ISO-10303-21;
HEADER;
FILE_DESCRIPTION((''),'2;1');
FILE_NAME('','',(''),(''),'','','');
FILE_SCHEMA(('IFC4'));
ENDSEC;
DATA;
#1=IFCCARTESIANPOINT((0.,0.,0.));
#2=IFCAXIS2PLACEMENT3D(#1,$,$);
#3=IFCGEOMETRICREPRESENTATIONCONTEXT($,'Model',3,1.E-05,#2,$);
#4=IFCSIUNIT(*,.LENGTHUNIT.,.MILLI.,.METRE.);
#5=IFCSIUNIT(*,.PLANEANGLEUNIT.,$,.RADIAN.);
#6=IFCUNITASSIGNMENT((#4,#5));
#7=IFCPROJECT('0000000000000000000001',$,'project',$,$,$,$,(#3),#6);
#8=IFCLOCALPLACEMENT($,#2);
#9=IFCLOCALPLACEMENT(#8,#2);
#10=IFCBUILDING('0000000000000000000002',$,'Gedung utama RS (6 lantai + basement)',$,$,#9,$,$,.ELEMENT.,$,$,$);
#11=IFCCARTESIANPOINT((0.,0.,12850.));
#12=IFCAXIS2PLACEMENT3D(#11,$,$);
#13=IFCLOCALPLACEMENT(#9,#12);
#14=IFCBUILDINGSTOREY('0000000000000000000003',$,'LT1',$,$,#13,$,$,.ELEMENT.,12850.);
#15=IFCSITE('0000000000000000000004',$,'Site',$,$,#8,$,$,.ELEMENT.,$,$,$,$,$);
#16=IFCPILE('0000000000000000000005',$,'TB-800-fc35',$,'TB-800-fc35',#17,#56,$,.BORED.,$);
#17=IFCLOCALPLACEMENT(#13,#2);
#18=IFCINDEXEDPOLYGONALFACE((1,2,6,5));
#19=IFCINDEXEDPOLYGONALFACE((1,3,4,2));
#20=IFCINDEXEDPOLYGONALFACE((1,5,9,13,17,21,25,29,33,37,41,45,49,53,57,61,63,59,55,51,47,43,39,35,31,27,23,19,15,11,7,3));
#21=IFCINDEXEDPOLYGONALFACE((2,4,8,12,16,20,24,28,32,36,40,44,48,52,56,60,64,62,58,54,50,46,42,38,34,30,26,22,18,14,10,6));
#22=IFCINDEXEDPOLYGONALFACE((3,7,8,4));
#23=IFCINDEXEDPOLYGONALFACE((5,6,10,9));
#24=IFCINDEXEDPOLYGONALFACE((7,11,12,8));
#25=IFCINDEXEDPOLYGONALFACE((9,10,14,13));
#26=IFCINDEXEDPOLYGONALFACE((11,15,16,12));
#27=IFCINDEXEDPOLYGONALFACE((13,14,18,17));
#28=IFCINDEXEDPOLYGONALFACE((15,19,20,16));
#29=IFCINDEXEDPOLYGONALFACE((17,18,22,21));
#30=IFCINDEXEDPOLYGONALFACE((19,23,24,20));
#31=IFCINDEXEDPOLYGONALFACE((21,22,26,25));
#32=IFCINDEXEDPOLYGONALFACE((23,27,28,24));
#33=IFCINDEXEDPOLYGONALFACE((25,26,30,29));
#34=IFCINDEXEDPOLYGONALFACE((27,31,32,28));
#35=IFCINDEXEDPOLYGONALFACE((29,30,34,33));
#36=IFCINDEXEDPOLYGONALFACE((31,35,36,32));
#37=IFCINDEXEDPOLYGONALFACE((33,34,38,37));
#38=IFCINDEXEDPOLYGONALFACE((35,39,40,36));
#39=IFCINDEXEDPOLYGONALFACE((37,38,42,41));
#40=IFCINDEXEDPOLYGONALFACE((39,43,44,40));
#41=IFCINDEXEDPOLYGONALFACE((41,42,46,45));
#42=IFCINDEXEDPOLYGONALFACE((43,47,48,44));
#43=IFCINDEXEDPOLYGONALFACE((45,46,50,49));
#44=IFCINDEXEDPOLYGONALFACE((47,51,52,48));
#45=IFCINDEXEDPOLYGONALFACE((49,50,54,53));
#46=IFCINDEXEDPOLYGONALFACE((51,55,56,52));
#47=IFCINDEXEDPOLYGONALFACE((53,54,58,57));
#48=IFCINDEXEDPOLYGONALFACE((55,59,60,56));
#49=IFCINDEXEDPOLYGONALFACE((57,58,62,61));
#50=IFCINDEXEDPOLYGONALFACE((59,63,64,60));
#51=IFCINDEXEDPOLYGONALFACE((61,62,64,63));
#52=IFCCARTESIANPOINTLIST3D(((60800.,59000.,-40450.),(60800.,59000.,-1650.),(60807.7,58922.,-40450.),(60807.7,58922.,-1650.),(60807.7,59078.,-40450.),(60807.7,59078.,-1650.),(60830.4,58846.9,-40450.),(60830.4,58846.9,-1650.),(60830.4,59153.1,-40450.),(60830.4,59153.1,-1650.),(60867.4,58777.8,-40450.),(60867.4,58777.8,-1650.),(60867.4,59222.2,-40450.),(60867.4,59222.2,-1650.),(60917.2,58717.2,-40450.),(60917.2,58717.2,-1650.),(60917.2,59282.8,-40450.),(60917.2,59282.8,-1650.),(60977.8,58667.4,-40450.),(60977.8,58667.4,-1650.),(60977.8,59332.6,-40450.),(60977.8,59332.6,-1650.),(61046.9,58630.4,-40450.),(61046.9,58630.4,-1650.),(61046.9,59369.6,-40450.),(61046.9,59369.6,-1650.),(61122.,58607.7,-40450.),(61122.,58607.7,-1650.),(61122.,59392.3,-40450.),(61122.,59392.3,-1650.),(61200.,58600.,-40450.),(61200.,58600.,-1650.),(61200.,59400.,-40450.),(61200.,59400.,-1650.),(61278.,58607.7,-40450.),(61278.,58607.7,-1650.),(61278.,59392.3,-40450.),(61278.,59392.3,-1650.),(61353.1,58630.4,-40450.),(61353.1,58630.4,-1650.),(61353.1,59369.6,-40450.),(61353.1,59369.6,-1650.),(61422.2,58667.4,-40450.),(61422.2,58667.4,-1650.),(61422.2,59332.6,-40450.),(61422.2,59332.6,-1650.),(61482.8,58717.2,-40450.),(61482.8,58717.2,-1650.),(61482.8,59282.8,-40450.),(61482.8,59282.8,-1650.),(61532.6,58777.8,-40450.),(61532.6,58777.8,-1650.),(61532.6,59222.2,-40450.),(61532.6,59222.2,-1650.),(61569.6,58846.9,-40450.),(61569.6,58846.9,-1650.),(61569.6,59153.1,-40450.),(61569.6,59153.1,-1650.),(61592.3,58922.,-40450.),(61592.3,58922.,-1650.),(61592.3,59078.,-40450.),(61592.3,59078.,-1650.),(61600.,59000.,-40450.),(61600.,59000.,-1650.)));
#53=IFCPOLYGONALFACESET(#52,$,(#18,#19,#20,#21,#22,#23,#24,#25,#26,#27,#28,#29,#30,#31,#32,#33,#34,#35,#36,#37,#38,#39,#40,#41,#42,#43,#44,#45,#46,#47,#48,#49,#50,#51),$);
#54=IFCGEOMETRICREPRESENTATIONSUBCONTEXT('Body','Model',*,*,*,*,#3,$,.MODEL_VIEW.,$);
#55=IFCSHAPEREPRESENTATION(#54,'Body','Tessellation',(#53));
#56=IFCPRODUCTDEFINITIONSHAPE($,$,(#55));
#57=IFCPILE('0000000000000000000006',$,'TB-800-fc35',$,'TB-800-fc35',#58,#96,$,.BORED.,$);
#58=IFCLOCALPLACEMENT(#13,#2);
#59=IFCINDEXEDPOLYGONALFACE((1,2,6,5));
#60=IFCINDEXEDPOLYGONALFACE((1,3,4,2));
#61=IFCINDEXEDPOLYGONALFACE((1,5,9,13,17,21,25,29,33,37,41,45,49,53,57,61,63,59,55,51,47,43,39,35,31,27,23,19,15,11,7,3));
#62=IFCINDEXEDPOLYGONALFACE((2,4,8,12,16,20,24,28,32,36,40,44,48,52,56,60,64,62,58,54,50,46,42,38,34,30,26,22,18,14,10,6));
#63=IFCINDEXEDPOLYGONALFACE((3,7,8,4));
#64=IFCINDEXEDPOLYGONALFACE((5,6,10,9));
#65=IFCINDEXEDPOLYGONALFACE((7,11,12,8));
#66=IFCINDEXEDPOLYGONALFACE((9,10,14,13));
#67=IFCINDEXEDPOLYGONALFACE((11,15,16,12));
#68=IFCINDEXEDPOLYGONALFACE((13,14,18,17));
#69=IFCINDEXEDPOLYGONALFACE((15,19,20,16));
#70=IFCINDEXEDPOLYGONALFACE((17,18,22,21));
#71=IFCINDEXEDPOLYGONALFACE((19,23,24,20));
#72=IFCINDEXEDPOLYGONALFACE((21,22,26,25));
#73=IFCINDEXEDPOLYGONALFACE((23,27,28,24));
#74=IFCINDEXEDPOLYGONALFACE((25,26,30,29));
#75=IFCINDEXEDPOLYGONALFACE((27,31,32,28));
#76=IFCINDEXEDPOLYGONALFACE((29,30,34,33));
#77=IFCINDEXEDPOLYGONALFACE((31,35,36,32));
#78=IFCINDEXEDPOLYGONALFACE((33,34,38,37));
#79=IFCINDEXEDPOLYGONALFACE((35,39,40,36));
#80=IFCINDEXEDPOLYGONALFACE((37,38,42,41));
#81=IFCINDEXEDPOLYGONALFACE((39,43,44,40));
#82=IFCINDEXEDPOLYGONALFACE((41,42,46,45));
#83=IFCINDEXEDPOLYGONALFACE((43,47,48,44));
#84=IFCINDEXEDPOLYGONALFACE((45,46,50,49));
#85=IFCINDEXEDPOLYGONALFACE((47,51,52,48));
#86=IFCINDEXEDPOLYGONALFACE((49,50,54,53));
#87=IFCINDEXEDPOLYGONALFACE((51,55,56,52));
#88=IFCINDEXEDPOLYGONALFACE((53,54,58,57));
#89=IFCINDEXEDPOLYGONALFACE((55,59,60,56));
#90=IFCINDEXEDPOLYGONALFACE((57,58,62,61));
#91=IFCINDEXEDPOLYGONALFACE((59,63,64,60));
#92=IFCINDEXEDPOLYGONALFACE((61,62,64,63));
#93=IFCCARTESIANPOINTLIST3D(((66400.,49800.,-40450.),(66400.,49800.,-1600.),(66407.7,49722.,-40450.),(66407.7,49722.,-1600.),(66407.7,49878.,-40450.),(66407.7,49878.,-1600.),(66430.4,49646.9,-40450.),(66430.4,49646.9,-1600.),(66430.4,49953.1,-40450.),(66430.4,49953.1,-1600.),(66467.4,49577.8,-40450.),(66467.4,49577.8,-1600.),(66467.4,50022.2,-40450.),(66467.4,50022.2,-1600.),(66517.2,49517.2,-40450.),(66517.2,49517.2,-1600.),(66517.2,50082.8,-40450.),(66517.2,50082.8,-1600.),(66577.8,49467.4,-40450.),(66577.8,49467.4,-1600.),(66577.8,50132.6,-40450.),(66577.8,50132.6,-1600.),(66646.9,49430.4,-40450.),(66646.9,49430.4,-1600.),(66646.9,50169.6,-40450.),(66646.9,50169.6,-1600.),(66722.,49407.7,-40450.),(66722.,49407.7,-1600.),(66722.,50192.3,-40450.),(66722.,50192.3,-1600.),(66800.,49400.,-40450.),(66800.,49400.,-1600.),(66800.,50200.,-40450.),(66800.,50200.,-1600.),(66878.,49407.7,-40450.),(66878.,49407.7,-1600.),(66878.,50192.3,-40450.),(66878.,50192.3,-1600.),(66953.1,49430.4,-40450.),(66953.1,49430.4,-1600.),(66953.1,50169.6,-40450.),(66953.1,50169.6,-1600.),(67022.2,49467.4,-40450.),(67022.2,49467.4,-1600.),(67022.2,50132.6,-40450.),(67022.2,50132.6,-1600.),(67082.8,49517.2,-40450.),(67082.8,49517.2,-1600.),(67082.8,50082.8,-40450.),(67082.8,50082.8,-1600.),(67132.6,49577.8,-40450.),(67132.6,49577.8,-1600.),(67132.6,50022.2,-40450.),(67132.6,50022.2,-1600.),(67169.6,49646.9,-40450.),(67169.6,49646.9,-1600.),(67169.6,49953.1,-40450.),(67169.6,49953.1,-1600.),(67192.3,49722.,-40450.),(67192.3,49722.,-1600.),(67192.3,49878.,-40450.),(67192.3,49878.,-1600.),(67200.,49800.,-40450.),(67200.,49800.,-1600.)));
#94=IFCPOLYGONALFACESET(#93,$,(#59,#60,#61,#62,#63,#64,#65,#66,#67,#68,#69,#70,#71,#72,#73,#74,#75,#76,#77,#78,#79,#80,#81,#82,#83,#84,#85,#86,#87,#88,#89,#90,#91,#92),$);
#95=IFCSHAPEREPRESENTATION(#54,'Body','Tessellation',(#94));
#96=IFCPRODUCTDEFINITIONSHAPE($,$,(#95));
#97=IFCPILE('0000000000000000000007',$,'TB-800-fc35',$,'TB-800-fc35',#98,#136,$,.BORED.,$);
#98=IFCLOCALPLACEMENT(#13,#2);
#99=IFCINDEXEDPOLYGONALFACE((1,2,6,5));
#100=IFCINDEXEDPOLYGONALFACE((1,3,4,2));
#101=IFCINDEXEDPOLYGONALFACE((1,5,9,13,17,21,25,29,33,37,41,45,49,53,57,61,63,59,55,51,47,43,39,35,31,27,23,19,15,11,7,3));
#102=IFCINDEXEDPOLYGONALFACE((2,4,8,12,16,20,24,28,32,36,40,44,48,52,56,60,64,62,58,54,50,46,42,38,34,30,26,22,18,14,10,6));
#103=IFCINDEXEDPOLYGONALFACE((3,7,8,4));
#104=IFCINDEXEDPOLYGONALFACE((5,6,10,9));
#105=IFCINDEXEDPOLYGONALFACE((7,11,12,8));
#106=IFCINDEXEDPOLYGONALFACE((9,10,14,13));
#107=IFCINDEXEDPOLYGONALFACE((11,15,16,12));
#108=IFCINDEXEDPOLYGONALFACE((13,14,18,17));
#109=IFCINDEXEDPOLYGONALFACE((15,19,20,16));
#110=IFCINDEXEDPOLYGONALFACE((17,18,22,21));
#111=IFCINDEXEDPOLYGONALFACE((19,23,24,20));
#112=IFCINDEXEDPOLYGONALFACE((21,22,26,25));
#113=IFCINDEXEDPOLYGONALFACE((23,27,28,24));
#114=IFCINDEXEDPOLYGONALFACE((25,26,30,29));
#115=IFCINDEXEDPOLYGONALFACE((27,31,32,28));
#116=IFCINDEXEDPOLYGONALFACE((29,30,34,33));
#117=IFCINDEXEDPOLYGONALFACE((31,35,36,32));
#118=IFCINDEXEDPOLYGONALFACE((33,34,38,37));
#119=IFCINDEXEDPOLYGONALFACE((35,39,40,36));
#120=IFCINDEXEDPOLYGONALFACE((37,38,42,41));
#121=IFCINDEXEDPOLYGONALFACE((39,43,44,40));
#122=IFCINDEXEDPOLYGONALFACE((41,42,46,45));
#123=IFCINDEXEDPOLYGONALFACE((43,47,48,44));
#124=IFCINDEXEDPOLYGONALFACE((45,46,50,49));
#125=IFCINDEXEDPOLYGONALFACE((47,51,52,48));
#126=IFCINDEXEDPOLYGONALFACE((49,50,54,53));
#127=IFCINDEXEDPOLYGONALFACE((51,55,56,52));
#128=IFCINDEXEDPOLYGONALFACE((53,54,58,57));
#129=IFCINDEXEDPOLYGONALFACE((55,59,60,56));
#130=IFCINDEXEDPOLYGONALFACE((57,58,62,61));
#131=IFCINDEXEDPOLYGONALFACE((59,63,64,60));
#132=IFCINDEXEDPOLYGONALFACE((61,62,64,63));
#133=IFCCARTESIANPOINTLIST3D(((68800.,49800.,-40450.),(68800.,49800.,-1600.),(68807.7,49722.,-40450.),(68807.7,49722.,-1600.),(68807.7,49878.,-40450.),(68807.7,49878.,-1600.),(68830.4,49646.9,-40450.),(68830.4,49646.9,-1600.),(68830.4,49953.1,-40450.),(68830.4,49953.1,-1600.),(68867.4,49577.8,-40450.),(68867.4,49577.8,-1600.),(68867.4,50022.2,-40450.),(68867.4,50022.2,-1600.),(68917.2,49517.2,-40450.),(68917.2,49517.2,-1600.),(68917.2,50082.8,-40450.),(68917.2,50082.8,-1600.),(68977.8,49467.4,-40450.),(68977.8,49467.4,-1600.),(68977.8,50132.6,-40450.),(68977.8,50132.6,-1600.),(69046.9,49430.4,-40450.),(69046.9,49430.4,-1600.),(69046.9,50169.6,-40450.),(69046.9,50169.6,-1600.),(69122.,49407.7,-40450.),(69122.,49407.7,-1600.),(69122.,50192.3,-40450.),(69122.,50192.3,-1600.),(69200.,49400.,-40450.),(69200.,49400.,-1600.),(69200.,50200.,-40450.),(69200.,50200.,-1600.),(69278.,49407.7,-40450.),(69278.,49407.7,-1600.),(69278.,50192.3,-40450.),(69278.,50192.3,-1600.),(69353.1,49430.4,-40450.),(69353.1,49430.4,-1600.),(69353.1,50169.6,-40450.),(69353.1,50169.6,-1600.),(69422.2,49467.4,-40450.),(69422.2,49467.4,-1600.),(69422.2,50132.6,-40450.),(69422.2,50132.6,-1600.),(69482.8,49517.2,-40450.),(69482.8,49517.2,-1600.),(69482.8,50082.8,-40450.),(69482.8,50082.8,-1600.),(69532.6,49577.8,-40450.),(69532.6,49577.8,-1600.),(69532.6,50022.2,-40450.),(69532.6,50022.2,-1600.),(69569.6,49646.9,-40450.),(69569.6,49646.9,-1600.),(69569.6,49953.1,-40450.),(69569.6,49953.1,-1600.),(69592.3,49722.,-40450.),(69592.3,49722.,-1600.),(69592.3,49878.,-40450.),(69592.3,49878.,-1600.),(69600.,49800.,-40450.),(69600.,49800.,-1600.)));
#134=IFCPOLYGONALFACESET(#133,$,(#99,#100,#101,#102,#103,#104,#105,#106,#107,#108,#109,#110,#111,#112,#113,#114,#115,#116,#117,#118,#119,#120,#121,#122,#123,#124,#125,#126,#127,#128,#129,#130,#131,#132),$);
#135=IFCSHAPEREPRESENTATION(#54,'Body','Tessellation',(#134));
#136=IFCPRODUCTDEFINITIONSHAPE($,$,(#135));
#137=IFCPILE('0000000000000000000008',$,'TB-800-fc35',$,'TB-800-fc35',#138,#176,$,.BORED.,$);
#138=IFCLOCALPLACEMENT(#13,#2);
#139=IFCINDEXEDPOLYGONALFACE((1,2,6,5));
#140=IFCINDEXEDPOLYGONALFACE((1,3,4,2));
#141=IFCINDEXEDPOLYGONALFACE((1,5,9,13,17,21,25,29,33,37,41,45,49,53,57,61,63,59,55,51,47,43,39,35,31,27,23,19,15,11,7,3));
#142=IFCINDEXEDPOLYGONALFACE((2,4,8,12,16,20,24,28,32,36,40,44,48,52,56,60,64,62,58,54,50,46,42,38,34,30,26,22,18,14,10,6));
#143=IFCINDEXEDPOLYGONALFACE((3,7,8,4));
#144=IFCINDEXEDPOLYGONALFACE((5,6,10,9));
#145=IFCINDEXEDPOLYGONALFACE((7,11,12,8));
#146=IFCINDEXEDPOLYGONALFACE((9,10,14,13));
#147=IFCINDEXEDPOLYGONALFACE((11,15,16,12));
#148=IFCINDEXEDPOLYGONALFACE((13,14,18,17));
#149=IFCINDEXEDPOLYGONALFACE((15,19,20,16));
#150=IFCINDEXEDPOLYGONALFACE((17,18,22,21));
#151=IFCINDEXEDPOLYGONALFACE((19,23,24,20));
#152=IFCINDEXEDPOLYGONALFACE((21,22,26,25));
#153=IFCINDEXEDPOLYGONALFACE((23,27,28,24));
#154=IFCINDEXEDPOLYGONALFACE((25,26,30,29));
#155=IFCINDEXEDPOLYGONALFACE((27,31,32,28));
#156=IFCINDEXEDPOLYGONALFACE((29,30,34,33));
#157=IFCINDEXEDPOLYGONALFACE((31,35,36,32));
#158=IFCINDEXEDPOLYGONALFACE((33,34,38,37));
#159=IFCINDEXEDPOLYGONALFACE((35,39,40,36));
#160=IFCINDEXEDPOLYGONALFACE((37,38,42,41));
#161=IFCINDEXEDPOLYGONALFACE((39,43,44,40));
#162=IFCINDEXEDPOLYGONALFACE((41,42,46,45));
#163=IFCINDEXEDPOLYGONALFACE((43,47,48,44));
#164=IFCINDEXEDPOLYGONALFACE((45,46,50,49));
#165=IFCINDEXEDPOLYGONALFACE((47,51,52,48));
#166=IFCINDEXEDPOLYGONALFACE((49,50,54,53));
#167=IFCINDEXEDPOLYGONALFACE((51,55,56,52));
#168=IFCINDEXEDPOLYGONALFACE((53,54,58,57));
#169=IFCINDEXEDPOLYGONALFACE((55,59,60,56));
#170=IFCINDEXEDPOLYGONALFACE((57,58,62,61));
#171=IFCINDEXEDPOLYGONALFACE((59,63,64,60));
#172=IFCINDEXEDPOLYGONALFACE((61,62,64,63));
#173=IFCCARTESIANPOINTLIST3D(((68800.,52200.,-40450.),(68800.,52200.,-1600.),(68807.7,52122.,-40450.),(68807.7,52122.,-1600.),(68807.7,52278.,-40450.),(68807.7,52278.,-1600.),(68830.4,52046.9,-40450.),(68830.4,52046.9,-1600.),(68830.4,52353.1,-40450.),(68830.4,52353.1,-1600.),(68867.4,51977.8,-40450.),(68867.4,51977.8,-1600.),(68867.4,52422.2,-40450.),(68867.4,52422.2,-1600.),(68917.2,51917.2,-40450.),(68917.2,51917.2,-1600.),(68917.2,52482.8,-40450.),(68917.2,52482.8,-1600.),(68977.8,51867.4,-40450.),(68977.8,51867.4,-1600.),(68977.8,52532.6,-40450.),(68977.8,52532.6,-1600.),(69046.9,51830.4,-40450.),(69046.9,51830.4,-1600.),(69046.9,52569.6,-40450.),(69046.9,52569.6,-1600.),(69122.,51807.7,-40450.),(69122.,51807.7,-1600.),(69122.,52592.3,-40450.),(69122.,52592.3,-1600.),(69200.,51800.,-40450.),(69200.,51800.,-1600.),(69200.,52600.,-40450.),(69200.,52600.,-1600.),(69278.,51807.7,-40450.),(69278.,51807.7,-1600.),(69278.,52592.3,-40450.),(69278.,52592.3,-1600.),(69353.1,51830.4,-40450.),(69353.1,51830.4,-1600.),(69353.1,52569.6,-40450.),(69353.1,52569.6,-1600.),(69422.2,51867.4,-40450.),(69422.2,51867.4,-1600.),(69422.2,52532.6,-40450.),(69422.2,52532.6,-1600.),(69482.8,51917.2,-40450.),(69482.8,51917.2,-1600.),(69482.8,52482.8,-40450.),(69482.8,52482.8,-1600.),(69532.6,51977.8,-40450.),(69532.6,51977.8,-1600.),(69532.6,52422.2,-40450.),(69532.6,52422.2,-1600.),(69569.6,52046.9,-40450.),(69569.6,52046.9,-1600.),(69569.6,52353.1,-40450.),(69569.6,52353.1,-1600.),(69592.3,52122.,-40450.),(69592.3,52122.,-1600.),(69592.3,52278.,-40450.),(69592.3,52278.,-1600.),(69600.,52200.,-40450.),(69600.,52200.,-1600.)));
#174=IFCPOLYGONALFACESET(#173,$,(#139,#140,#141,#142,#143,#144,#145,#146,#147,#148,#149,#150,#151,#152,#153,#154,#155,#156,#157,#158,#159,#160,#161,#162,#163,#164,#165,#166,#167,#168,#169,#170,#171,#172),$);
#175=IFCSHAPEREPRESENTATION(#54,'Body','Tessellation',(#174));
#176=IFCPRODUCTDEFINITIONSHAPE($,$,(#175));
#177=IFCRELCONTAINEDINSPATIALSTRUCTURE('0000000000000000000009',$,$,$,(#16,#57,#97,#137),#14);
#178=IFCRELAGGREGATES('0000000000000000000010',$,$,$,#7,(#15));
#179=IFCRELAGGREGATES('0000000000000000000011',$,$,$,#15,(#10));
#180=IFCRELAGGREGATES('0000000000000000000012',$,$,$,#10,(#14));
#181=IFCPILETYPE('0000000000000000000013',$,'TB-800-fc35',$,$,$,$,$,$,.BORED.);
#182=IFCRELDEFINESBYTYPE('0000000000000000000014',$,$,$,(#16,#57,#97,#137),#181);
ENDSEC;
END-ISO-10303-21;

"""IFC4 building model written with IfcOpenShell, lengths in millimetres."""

from ifc_helpers import new_model, si_unit, frame, origin, origin_2d, place, context, subcontext, project, spatial, circle, extrude, material_profile, profile_set, profile_usage, type_object, element, save


model = new_model("IFC4")

# Units and contexts
model_context = context("Model", 3, precision=1e-05, world=origin())
body_context = subcontext(model_context, "Body", "Model", "MODEL_VIEW")
ifc_project = project(units=[si_unit("LENGTHUNIT", "METRE", prefix="MILLI"), si_unit("PLANEANGLEUNIT", "RADIAN")], contexts=[model_context])

# Site, building, storey
site_placement = place(None, origin())
site = spatial("IfcSite", under=ifc_project, at=site_placement, Name="Site", CompositionType="ELEMENT")
building_placement = place(site_placement, origin())
building = spatial("IfcBuilding", under=site, at=building_placement, Name="Gedung utama RS (6 lantai + basement)", CompositionType="ELEMENT")
storey_placement = place(building_placement, frame((0.0, 0.0, 12850.0)))
storey = spatial("IfcBuildingStorey", under=building, at=storey_placement, Name="LT1", CompositionType="ELEMENT", Elevation=12850.0)

# Piles
ifc_material_profile = material_profile(None, circle(Radius=400.0, at=origin_2d()), Name="TB-800-fc35")
ifc_profile_set = profile_set([ifc_material_profile], Name="TB-800-fc35")
ifc_profile_usage = profile_usage(ifc_profile_set, cardinal=5)
pile_type = type_object("IfcPileType", Name="TB-800-fc35", PredefinedType="BORED", material=ifc_profile_set)
for number, where, z_axis, x_axis, name in (
    (1, (61200.0, 59000.0, -40450.0), (0.0, 0.0, 1.0), (1.0, 0.0, 0.0), "TB-800-fc35"),
):
    element("IfcPile", number, at=place(storey_placement, frame(where, z_axis=z_axis, x_axis=x_axis)), inside=storey, type_object=pile_type, material=ifc_profile_usage, Name=name, ObjectType="TB-800-fc35", PredefinedType="BORED", context=body_context, shape_type="SweptSolid", body=[
        extrude(circle(Radius=400.0, at=origin_2d()), origin(), (0.0, 0.0, 1.0), 38800.0),
    ])
for number, where, z_axis, x_axis, name in (
    (2, (66800.0, 49800.0, -40450.0), (0.0, 0.0, 1.0), (1.0, 0.0, 0.0), "TB-800-fc35"),
    (3, (69200.0, 49800.0, -40450.0), (0.0, 0.0, 1.0), (1.0, 0.0, 0.0), "TB-800-fc35"),
    (4, (69200.0, 52200.0, -40450.0), (0.0, 0.0, 1.0), (1.0, 0.0, 0.0), "TB-800-fc35"),
):
    element("IfcPile", number, at=place(storey_placement, frame(where, z_axis=z_axis, x_axis=x_axis)), inside=storey, type_object=pile_type, material=ifc_profile_usage, Name=name, ObjectType="TB-800-fc35", PredefinedType="BORED", context=body_context, shape_type="SweptSolid", body=[
        extrude(circle(Radius=400.0, at=origin_2d()), origin(), (0.0, 0.0, 1.0), 38850.0),
    ])

save(model, "model.ifc")
